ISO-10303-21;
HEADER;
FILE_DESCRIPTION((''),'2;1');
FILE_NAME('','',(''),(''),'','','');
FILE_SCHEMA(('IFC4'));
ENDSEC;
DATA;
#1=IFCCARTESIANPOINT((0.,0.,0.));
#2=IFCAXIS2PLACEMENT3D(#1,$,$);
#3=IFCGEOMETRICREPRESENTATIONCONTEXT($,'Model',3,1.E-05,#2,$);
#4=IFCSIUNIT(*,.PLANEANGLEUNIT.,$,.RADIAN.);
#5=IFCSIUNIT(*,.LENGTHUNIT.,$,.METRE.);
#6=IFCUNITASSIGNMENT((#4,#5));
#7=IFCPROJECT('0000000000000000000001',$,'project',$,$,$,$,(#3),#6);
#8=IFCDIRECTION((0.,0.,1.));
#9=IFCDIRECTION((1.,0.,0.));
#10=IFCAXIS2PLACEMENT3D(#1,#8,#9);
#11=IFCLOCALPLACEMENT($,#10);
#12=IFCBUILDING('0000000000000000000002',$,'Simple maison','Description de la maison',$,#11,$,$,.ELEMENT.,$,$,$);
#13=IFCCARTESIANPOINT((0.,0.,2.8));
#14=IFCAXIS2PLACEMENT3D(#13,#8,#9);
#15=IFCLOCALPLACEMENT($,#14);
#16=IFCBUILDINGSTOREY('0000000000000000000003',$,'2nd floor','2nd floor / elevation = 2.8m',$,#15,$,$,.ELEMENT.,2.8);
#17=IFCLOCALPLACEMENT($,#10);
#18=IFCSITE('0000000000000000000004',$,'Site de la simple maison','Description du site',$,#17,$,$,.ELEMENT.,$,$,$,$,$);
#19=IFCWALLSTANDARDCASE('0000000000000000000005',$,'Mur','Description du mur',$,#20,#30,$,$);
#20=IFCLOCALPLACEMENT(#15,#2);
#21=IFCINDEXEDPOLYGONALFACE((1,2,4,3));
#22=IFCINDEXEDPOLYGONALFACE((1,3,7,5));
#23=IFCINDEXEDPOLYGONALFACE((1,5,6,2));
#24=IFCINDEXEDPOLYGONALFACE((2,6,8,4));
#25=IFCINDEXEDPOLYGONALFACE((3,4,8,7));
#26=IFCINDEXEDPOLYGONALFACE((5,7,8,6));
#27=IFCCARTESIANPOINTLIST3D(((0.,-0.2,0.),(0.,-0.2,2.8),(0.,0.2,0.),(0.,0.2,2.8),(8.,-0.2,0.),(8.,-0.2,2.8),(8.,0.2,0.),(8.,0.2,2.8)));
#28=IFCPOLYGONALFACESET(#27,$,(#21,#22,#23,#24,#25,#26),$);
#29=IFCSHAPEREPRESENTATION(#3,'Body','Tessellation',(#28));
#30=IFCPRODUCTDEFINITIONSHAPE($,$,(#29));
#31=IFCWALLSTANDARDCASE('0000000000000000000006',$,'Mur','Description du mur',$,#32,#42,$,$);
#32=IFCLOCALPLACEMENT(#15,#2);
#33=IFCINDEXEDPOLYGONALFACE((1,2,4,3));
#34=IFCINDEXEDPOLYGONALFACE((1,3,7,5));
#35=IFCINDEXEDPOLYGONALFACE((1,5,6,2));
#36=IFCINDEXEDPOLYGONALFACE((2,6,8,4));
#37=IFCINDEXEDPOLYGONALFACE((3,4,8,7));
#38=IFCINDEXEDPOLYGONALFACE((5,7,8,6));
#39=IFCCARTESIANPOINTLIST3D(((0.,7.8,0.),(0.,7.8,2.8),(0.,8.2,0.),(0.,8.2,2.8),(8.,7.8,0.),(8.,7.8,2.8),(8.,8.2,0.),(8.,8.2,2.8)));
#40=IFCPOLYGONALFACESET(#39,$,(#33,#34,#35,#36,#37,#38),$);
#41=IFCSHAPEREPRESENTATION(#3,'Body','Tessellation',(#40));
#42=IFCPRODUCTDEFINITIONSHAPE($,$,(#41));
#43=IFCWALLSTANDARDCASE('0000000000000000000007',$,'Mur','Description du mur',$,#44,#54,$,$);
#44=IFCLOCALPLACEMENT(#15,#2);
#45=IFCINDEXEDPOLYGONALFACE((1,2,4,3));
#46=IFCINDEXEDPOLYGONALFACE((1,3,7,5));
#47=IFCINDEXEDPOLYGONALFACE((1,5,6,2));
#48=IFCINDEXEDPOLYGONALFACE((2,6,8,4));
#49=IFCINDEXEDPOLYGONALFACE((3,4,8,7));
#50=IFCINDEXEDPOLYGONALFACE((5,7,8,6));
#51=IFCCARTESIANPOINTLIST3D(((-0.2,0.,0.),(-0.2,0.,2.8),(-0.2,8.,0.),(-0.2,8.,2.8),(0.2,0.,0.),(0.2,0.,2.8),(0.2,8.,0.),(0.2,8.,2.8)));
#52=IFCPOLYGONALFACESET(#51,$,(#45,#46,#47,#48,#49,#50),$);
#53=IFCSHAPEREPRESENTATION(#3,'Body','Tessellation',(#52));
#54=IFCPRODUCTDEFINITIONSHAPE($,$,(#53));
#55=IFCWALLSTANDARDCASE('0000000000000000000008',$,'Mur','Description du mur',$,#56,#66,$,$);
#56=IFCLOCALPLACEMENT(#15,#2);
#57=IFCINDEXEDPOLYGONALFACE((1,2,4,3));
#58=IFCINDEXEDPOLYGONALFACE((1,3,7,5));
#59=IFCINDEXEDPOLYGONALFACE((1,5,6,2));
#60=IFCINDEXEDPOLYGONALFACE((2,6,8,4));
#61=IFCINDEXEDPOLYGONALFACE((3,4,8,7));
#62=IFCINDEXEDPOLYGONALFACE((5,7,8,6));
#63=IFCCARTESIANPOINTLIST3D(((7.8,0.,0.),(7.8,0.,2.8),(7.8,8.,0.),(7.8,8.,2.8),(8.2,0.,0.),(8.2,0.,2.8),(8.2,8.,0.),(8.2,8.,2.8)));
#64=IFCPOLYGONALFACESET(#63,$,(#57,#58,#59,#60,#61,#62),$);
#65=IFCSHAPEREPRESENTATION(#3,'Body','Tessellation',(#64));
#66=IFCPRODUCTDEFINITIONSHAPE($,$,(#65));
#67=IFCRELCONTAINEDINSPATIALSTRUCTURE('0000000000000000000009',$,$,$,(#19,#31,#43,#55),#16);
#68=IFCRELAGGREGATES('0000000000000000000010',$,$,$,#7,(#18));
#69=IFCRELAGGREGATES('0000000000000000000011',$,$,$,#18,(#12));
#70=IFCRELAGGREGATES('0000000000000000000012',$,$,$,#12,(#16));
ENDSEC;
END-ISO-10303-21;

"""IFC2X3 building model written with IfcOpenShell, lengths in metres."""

from ifc_helpers import new_model, si_unit, frame, origin, origin_with_axes, place, context, project, spatial, polyline, outline, extrude, element, save


model = new_model("IFC2X3")

# Units and contexts
model_context = context("Model", 3, precision=1e-05, world=origin())
ifc_project = project(units=[si_unit("PLANEANGLEUNIT", "RADIAN"), si_unit("LENGTHUNIT", "METRE")], contexts=[model_context])

# Site, building, storey
site_placement = place(None, origin_with_axes())
site = spatial("IfcSite", under=ifc_project, at=site_placement, Name="Site de la simple maison", Description="Description du site", CompositionType="ELEMENT")
building_placement = place(None, origin_with_axes())
building = spatial("IfcBuilding", under=site, at=building_placement, Name="Simple maison", Description="Description de la maison", CompositionType="ELEMENT")
storey_placement = place(None, frame((0.0, 0.0, 2.8), z_axis=(0.0, 0.0, 1.0), x_axis=(1.0, 0.0, 0.0)))
storey = spatial("IfcBuildingStorey", under=building, at=storey_placement, Name="2nd floor", Description="2nd floor / elevation = 2.8m", CompositionType="ELEMENT", Elevation=2.8)

# Walls
for number, where, z_axis, x_axis, name in (
    (1, (0.0, 0.0, 0.0), (0.0, 0.0, 1.0), (1.0, 0.0, 0.0), "Mur"),
    (2, (0.0, 8.0, 0.0), (0.0, 0.0, 1.0), (1.0, 0.0, 0.0), "Mur"),
    (3, (0.0, 0.0, 0.0), (0.0, 0.0, 1.0), (0.0, 1.0, 0.0), "Mur"),
    (4, (8.0, 0.0, 0.0), (0.0, 0.0, 1.0), (0.0, 1.0, 0.0), "Mur"),
):
    element("IfcWallStandardCase", number, at=place(storey_placement, frame(where, z_axis=z_axis, x_axis=x_axis)), inside=storey, Name=name, Description="Description du mur", context=model_context, shape_type="SweptSolid", body=[
        extrude(outline(polyline([(0.0, 0.2), (8.0, 0.2), (8.0, -0.2), (0.0, -0.2)])), origin_with_axes(), (0.0, 0.0, 1.0), 2.8),
    ])

save(model, "model.ifc")
